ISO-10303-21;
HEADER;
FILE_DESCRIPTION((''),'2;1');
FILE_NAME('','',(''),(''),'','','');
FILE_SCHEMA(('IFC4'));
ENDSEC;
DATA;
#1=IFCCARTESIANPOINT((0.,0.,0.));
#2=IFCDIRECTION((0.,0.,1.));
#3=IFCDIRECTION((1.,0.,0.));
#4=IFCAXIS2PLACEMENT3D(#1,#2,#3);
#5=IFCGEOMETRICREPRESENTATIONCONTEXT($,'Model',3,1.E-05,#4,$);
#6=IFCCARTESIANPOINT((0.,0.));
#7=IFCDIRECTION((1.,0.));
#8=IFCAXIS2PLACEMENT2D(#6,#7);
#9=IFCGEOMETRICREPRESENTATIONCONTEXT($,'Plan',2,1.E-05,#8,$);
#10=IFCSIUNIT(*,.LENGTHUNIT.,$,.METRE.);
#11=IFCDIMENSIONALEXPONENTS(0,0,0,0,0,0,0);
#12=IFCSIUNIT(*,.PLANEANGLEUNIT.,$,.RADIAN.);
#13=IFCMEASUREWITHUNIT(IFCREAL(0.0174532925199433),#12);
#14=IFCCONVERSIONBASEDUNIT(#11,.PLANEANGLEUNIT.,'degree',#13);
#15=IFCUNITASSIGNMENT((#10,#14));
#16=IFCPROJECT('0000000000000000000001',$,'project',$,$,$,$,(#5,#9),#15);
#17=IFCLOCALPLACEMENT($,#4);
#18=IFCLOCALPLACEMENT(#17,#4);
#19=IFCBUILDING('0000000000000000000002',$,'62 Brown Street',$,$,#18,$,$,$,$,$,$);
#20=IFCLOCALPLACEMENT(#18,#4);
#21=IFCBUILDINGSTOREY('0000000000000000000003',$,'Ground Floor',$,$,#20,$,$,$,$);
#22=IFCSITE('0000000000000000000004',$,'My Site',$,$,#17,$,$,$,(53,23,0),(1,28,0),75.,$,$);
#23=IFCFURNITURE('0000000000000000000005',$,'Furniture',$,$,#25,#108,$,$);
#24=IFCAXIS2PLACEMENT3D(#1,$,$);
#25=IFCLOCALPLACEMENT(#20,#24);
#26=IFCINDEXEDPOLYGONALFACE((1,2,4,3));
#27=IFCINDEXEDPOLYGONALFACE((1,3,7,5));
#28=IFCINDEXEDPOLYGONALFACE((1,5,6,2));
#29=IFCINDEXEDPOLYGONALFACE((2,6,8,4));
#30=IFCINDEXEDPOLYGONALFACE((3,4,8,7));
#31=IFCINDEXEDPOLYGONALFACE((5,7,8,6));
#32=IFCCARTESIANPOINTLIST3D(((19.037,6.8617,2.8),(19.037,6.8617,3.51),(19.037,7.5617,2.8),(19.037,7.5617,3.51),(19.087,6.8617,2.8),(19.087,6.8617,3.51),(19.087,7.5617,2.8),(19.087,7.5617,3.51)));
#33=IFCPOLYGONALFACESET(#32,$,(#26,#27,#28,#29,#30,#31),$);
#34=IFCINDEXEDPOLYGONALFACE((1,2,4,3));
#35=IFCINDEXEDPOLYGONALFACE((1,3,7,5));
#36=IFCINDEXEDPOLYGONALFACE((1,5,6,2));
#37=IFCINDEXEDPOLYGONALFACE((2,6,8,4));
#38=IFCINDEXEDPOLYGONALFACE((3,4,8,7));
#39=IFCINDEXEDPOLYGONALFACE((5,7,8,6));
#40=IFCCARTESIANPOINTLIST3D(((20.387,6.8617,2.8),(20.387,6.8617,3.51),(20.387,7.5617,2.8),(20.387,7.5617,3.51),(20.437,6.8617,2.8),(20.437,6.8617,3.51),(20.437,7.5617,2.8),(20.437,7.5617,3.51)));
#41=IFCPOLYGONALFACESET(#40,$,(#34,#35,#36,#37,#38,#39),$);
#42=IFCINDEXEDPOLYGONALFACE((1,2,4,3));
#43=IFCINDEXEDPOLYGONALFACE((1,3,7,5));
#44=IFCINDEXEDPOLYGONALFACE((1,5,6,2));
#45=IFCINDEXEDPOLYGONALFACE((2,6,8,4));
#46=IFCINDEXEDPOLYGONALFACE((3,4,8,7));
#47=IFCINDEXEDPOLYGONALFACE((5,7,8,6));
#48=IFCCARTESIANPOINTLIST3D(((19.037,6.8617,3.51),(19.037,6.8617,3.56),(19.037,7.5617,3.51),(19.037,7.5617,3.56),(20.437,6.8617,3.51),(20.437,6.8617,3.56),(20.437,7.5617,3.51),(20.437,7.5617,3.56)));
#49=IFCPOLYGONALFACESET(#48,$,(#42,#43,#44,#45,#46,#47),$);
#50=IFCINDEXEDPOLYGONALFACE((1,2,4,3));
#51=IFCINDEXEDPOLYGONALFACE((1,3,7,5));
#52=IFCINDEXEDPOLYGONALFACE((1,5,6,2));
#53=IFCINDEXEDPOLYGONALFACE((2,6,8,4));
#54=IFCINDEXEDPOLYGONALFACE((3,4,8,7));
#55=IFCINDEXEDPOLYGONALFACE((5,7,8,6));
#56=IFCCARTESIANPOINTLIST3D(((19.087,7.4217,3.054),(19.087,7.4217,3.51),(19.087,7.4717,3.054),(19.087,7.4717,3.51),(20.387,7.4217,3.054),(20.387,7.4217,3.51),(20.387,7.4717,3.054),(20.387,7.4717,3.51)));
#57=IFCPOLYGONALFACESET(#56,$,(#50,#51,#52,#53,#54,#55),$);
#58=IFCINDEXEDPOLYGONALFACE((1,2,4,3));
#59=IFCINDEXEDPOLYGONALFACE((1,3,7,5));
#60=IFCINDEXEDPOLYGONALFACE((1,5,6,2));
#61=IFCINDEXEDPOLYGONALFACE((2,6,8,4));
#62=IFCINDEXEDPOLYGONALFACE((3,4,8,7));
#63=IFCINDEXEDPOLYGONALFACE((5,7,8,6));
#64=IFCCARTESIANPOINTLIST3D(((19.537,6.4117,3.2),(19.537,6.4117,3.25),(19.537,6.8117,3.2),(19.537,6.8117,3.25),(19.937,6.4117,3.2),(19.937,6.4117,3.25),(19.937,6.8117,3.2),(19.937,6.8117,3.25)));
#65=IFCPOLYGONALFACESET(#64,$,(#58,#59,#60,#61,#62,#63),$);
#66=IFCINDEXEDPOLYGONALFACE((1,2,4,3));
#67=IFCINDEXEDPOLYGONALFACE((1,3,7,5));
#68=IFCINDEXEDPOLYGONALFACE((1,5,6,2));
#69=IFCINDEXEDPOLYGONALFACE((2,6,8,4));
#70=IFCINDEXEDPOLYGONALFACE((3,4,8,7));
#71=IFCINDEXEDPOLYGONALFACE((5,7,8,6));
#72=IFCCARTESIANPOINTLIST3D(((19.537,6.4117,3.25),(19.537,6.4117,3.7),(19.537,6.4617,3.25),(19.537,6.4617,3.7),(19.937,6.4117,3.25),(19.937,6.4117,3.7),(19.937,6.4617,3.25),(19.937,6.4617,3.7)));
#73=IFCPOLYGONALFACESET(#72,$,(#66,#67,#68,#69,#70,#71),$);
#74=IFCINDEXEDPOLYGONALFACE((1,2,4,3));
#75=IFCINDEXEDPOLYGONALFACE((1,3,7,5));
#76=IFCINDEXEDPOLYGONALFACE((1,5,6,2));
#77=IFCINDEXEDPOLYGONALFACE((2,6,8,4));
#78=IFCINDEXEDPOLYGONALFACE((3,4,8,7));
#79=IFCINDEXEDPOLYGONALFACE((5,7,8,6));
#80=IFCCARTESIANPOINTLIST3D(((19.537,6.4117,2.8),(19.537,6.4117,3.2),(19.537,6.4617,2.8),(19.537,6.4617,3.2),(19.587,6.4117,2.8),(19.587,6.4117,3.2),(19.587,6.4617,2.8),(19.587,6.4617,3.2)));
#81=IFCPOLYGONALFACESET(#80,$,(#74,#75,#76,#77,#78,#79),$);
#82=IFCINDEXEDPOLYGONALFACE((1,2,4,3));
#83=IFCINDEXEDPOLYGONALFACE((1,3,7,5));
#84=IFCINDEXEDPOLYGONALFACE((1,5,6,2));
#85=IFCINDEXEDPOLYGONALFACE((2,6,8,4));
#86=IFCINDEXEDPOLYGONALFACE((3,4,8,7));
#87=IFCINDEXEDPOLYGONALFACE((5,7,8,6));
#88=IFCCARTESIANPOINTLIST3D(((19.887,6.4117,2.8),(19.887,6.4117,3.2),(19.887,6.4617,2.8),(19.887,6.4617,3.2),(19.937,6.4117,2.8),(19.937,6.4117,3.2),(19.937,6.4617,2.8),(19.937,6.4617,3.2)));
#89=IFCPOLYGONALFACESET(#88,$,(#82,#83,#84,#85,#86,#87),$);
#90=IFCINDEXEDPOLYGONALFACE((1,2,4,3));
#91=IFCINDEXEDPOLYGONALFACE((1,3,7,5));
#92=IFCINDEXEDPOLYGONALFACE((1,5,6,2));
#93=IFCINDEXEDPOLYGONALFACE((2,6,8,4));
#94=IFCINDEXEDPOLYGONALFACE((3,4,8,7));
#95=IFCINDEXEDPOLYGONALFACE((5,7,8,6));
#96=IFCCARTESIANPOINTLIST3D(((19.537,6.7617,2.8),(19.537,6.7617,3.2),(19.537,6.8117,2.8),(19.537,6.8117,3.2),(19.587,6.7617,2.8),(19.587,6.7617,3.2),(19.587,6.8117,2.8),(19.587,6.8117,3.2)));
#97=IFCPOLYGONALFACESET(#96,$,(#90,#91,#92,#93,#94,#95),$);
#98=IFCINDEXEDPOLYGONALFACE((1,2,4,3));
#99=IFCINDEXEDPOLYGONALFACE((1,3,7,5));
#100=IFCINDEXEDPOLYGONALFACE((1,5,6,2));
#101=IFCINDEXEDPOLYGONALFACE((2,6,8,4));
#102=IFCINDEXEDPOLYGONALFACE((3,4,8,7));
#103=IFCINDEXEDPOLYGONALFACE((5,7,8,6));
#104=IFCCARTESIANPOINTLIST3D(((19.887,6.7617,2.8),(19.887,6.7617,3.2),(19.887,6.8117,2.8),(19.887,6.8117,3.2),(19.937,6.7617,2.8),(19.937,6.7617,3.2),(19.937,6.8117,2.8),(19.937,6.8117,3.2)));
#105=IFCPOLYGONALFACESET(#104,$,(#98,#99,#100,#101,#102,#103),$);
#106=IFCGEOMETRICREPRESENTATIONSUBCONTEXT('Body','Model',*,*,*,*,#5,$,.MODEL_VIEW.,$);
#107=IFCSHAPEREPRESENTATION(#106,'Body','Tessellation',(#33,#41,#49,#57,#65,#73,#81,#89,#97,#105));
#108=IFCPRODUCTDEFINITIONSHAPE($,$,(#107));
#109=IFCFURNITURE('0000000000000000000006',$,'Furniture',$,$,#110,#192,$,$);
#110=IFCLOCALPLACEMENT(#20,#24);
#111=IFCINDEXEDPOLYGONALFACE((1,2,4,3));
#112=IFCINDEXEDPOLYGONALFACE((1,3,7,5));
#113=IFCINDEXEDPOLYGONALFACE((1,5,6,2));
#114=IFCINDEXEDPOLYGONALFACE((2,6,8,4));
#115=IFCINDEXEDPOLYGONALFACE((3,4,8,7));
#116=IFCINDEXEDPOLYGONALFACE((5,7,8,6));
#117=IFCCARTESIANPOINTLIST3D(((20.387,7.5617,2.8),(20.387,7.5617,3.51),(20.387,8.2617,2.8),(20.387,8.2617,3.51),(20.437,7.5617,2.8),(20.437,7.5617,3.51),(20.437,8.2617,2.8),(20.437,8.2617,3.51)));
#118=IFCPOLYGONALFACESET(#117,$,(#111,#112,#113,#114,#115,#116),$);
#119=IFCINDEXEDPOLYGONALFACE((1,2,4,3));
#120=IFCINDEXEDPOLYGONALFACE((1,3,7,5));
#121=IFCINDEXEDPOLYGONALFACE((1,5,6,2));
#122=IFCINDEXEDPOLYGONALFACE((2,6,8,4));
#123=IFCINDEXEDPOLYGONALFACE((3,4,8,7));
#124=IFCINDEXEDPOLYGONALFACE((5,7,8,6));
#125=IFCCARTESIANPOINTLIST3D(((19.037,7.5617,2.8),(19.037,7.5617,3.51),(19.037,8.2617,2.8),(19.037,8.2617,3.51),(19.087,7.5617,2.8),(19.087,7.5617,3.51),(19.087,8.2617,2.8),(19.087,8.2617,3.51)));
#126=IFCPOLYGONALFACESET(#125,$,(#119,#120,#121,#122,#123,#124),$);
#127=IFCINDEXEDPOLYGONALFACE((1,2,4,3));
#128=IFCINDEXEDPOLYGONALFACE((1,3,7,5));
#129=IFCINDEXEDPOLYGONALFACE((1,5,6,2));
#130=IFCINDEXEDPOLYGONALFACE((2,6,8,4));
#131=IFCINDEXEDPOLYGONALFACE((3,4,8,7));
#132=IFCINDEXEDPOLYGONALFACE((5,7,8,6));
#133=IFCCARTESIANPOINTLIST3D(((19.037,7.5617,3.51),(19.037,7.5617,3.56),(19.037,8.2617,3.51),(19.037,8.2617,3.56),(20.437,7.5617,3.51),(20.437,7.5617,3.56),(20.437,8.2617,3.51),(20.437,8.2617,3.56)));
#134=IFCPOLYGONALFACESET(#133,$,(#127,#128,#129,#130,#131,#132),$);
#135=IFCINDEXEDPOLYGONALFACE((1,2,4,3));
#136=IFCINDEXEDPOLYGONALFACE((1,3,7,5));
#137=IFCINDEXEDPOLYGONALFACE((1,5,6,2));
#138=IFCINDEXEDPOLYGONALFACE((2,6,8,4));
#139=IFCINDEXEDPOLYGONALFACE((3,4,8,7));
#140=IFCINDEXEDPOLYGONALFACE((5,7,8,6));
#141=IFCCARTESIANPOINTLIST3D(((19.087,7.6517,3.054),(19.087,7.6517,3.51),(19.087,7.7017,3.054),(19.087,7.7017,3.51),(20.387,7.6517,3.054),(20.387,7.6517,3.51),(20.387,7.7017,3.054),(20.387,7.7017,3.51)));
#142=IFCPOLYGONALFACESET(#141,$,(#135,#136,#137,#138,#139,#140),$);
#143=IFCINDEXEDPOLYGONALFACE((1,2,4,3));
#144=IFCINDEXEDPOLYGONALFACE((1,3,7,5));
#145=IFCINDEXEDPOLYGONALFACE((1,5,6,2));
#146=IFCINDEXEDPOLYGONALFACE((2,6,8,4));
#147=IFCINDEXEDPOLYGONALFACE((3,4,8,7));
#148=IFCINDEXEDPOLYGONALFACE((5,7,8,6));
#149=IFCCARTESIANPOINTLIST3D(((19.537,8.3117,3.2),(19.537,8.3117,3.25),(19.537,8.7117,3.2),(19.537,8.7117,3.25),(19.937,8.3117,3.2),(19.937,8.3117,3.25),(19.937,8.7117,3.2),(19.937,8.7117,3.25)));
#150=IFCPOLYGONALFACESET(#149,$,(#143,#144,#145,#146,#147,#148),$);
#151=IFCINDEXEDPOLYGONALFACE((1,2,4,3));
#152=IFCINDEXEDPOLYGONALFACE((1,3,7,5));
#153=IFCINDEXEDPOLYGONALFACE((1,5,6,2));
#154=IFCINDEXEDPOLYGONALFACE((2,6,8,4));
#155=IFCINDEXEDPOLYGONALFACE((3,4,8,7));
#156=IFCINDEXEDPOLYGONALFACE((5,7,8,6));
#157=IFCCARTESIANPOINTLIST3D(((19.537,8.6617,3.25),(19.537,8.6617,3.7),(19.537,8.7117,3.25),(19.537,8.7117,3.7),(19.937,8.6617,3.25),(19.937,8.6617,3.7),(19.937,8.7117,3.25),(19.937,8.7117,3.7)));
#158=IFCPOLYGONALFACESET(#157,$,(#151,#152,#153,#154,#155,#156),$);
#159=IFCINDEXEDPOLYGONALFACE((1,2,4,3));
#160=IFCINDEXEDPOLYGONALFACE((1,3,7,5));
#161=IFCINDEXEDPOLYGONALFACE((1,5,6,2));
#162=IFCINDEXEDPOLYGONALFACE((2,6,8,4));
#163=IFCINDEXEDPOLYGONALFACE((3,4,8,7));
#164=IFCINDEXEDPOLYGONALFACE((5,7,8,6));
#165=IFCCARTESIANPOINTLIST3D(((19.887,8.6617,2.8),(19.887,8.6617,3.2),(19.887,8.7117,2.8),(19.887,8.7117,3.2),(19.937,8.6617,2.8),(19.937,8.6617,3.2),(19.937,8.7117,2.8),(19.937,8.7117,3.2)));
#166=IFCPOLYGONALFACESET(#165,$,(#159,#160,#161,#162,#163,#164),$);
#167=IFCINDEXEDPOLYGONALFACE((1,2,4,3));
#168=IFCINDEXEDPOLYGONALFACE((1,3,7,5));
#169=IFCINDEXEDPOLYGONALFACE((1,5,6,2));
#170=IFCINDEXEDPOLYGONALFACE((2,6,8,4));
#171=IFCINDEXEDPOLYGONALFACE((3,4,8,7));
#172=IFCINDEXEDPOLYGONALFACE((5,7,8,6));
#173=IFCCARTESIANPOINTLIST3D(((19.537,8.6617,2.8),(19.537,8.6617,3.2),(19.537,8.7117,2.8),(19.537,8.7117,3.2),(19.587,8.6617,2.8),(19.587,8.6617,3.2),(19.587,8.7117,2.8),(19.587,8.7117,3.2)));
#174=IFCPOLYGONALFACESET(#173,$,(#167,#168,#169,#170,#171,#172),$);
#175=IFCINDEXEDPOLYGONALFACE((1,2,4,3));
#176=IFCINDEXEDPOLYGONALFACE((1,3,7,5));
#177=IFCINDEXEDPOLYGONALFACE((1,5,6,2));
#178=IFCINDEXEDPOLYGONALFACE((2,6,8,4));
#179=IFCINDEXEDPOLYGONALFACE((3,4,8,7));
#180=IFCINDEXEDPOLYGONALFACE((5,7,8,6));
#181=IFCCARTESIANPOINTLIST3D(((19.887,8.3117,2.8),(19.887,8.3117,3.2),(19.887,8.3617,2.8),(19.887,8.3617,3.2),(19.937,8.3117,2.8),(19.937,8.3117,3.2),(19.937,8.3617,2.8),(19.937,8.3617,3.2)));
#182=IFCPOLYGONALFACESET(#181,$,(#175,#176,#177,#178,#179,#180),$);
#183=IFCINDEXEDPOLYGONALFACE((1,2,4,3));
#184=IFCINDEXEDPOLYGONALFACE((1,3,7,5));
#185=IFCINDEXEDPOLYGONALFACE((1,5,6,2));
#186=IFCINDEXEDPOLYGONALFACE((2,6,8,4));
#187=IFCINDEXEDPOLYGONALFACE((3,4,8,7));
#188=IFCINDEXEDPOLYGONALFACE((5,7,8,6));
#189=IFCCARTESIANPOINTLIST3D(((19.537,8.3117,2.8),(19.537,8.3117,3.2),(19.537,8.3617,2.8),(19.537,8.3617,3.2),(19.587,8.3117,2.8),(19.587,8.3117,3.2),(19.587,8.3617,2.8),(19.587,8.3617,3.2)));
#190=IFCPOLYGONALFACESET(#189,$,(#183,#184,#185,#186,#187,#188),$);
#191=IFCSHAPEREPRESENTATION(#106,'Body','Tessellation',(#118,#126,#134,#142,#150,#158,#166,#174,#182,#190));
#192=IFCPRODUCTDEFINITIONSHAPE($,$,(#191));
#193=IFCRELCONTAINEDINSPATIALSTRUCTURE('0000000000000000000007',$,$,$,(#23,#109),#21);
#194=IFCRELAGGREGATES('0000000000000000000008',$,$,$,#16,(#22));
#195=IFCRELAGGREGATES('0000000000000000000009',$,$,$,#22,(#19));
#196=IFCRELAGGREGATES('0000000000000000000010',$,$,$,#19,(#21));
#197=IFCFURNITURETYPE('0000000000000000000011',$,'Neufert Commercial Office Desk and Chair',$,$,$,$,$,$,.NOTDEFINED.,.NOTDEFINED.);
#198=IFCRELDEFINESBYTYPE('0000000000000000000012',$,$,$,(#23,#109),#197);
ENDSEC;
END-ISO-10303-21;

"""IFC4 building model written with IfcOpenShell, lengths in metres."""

from ifc_helpers import new_model, entity, si_unit, converted_unit, frame, origin_with_axes, origin_2d_with_axis, place, context, subcontext, project, spatial, line, indexed_curve, outline, extrude, shape, source, transform, mapped, type_object, type_shapes, element, save


model = new_model("IFC4")

# Units and contexts
model_context = context("Model", 3, precision=1e-05, world=origin_with_axes())
plan_context = context("Plan", 2, precision=1e-05, world=origin_2d_with_axis())
body_context_1 = subcontext(model_context, "Body", "Model", "MODEL_VIEW")
body_context_2 = subcontext(plan_context, "Body", "Plan", "PLAN_VIEW")
ifc_project = project(units=[si_unit("LENGTHUNIT", "METRE"), converted_unit("PLANEANGLEUNIT", "degree", entity("IfcReal", 0.0174532925199433), si_unit("PLANEANGLEUNIT", "RADIAN"), dimensions=[0, 0, 0, 0, 0, 0, 0])], contexts=[model_context, plan_context])

# Site, building, storey
site_placement = place(None, origin_with_axes())
site = spatial("IfcSite", under=ifc_project, at=site_placement, Name="My Site", RefLatitude=(53, 23, 0), RefLongitude=(1, 28, 0), RefElevation=75.0)
building_placement = place(site_placement, origin_with_axes())
building = spatial("IfcBuilding", under=site, at=building_placement, Name="62 Brown Street")
storey_placement = place(building_placement, origin_with_axes())
storey = spatial("IfcBuildingStorey", under=building, at=storey_placement, Name="Ground Floor")

# Furniture
furniture_type_1 = type_object("IfcFurnitureType", Name="Neufert Commercial Office Desk and Chair", AssemblyPlace="NOTDEFINED", PredefinedType="NOTDEFINED")
shared_shape_1 = source(origin_with_axes(), body_context_1, "Body", "SweptSolid", [
    extrude(outline(indexed_curve([(0.0, 0.0), (0.05, 0.0), (0.05, 0.7), (0.0, 0.7)], segments=[line(1, 2, 3, 4, 1)])), frame((0.0, 0.45, 0.0), z_axis=(0.0, 0.0, 1.0), x_axis=(1.0, 0.0, 0.0)), (0.0, 0.0, 1.0), 0.71),
    extrude(outline(indexed_curve([(0.0, 0.0), (0.05, 0.0), (0.05, 0.7), (0.0, 0.7)], segments=[line(1, 2, 3, 4, 1)])), frame((1.35, 0.45, 0.0), z_axis=(0.0, 0.0, 1.0), x_axis=(1.0, 0.0, 0.0)), (0.0, 0.0, 1.0), 0.71),
    extrude(outline(indexed_curve([(0.0, 0.0), (1.4, 0.0), (1.4, 0.7), (0.0, 0.7)], segments=[line(1, 2, 3, 4, 1)])), frame((0.0, 0.45, 0.71), z_axis=(0.0, 0.0, 1.0), x_axis=(1.0, 0.0, 0.0)), (0.0, 0.0, 1.0), 0.05),
    extrude(outline(indexed_curve([(0.05, 0.56), (1.35, 0.56), (1.35, 0.61), (0.05, 0.61)], segments=[line(1, 2, 3, 4, 1)])), frame((0.0, 0.45, 0.254), z_axis=(0.0, 0.0, 1.0), x_axis=(1.0, 0.0, 0.0)), (0.0, 0.0, 1.0), 0.456),
    extrude(outline(indexed_curve([(-0.2, 0.0), (0.2, 0.0), (0.2, 0.4), (-0.2, 0.4)], segments=[line(1, 2, 3, 4, 1)])), frame((0.7, 0.0, 0.45), z_axis=(0.0, 0.0, 1.0), x_axis=(1.0, 0.0, 0.0)), (0.0, 0.0, -1.0), 0.05),
    extrude(outline(indexed_curve([(-0.2, 0.0), (0.2, 0.0), (0.2, 0.05), (-0.2, 0.05)], segments=[line(1, 2, 3, 4, 1)])), frame((0.7, 0.0, 0.9), z_axis=(0.0, 0.0, 1.0), x_axis=(1.0, 0.0, 0.0)), (0.0, 0.0, -1.0), 0.45),
    extrude(outline(indexed_curve([(-0.2, 0.0), (-0.15, 0.0), (-0.15, 0.05), (-0.2, 0.05)], segments=[line(1, 2, 3, 4, 1)])), frame((0.7, 0.0, 0.0), z_axis=(0.0, 0.0, 1.0), x_axis=(1.0, 0.0, 0.0)), (0.0, 0.0, 1.0), 0.4),
    extrude(outline(indexed_curve([(0.2, 0.0), (0.15, 0.0), (0.15, 0.05), (0.2, 0.05)], segments=[line(1, 2, 3, 4, 1)])), frame((0.7, 0.0, 0.0), z_axis=(0.0, 0.0, 1.0), x_axis=(1.0, 0.0, 0.0)), (0.0, 0.0, 1.0), 0.4),
    extrude(outline(indexed_curve([(-0.2, 0.4), (-0.15, 0.4), (-0.15, 0.35), (-0.2, 0.35)], segments=[line(1, 2, 3, 4, 1)])), frame((0.7, 0.0, 0.0), z_axis=(0.0, 0.0, 1.0), x_axis=(1.0, 0.0, 0.0)), (0.0, 0.0, 1.0), 0.4),
    extrude(outline(indexed_curve([(0.2, 0.4), (0.15, 0.4), (0.15, 0.35), (0.2, 0.35)], segments=[line(1, 2, 3, 4, 1)])), frame((0.7, 0.0, 0.0), z_axis=(0.0, 0.0, 1.0), x_axis=(1.0, 0.0, 0.0)), (0.0, 0.0, 1.0), 0.4),
])
shared_shape_2 = source(origin_with_axes(), body_context_2, "Body", "Curve2D", [
    entity("IfcIndexedPolyCurve", entity("IfcCartesianPointList2D", [[0.0, 0.45], [1.4, 0.45], [1.4, 1.15], [0.0, 1.15]]), [entity("IfcLineIndex", [1, 2, 3, 4, 1])]),
    entity("IfcIndexedPolyCurve", entity("IfcCartesianPointList2D", [[0.5, 0.4], [0.9, 0.4]])),
    entity("IfcIndexedPolyCurve", entity("IfcCartesianPointList2D", [[0.5, 0.4], [0.5, 0.2], [0.5586, 0.0586], [0.7, 0.0], [0.8414, 0.0586], [0.9, 0.2], [0.9, 0.4]]), [entity("IfcLineIndex", [1, 2]), entity("IfcArcIndex", [2, 3, 4]), entity("IfcArcIndex", [4, 5, 6]), entity("IfcLineIndex", [6, 7])]),
    entity("IfcIndexedPolyCurve", entity("IfcCartesianPointList2D", [[0.54, 0.4], [0.54, 0.2], [0.5869, 0.0869], [0.7, 0.04], [0.8131, 0.0869], [0.86, 0.2], [0.86, 0.4]]), [entity("IfcLineIndex", [1, 2]), entity("IfcArcIndex", [2, 3, 4]), entity("IfcArcIndex", [4, 5, 6]), entity("IfcLineIndex", [6, 7])]),
])
type_shapes(furniture_type_1, [shared_shape_1, shared_shape_2])
for number, where, z_axis, x_axis, name in (
    (1, (19.037, 6.4117, 2.8), (0.0, 0.0, 1.0), (1.0, 0.0, 0.0), "Furniture"),
    (2, (20.437, 8.7117, 2.8), (0.0, 0.0, 1.0), (-1.0, 0.0, 0.0), "Furniture"),
):
    element("IfcFurniture", number, at=place(storey_placement, frame(where, z_axis=z_axis, x_axis=x_axis)), inside=storey, type_object=furniture_type_1, Name=name, shapes=[
        shape(body_context_1, "Body", "MappedRepresentation", [mapped(shared_shape_1, transform((0.0, 0.0, 0.0), x_axis=(1.0, 0.0, 0.0), y_axis=(0.0, 1.0, 0.0), z_axis=(0.0, 0.0, 1.0), scale=1.0))]),
        shape(body_context_2, "Body", "MappedRepresentation", [mapped(shared_shape_2, transform((0.0, 0.0, 0.0), x_axis=(1.0, 0.0, 0.0), y_axis=(0.0, 1.0, 0.0), z_axis=(0.0, 0.0, 1.0), scale=1.0))]),
    ])

save(model, "model.ifc")
